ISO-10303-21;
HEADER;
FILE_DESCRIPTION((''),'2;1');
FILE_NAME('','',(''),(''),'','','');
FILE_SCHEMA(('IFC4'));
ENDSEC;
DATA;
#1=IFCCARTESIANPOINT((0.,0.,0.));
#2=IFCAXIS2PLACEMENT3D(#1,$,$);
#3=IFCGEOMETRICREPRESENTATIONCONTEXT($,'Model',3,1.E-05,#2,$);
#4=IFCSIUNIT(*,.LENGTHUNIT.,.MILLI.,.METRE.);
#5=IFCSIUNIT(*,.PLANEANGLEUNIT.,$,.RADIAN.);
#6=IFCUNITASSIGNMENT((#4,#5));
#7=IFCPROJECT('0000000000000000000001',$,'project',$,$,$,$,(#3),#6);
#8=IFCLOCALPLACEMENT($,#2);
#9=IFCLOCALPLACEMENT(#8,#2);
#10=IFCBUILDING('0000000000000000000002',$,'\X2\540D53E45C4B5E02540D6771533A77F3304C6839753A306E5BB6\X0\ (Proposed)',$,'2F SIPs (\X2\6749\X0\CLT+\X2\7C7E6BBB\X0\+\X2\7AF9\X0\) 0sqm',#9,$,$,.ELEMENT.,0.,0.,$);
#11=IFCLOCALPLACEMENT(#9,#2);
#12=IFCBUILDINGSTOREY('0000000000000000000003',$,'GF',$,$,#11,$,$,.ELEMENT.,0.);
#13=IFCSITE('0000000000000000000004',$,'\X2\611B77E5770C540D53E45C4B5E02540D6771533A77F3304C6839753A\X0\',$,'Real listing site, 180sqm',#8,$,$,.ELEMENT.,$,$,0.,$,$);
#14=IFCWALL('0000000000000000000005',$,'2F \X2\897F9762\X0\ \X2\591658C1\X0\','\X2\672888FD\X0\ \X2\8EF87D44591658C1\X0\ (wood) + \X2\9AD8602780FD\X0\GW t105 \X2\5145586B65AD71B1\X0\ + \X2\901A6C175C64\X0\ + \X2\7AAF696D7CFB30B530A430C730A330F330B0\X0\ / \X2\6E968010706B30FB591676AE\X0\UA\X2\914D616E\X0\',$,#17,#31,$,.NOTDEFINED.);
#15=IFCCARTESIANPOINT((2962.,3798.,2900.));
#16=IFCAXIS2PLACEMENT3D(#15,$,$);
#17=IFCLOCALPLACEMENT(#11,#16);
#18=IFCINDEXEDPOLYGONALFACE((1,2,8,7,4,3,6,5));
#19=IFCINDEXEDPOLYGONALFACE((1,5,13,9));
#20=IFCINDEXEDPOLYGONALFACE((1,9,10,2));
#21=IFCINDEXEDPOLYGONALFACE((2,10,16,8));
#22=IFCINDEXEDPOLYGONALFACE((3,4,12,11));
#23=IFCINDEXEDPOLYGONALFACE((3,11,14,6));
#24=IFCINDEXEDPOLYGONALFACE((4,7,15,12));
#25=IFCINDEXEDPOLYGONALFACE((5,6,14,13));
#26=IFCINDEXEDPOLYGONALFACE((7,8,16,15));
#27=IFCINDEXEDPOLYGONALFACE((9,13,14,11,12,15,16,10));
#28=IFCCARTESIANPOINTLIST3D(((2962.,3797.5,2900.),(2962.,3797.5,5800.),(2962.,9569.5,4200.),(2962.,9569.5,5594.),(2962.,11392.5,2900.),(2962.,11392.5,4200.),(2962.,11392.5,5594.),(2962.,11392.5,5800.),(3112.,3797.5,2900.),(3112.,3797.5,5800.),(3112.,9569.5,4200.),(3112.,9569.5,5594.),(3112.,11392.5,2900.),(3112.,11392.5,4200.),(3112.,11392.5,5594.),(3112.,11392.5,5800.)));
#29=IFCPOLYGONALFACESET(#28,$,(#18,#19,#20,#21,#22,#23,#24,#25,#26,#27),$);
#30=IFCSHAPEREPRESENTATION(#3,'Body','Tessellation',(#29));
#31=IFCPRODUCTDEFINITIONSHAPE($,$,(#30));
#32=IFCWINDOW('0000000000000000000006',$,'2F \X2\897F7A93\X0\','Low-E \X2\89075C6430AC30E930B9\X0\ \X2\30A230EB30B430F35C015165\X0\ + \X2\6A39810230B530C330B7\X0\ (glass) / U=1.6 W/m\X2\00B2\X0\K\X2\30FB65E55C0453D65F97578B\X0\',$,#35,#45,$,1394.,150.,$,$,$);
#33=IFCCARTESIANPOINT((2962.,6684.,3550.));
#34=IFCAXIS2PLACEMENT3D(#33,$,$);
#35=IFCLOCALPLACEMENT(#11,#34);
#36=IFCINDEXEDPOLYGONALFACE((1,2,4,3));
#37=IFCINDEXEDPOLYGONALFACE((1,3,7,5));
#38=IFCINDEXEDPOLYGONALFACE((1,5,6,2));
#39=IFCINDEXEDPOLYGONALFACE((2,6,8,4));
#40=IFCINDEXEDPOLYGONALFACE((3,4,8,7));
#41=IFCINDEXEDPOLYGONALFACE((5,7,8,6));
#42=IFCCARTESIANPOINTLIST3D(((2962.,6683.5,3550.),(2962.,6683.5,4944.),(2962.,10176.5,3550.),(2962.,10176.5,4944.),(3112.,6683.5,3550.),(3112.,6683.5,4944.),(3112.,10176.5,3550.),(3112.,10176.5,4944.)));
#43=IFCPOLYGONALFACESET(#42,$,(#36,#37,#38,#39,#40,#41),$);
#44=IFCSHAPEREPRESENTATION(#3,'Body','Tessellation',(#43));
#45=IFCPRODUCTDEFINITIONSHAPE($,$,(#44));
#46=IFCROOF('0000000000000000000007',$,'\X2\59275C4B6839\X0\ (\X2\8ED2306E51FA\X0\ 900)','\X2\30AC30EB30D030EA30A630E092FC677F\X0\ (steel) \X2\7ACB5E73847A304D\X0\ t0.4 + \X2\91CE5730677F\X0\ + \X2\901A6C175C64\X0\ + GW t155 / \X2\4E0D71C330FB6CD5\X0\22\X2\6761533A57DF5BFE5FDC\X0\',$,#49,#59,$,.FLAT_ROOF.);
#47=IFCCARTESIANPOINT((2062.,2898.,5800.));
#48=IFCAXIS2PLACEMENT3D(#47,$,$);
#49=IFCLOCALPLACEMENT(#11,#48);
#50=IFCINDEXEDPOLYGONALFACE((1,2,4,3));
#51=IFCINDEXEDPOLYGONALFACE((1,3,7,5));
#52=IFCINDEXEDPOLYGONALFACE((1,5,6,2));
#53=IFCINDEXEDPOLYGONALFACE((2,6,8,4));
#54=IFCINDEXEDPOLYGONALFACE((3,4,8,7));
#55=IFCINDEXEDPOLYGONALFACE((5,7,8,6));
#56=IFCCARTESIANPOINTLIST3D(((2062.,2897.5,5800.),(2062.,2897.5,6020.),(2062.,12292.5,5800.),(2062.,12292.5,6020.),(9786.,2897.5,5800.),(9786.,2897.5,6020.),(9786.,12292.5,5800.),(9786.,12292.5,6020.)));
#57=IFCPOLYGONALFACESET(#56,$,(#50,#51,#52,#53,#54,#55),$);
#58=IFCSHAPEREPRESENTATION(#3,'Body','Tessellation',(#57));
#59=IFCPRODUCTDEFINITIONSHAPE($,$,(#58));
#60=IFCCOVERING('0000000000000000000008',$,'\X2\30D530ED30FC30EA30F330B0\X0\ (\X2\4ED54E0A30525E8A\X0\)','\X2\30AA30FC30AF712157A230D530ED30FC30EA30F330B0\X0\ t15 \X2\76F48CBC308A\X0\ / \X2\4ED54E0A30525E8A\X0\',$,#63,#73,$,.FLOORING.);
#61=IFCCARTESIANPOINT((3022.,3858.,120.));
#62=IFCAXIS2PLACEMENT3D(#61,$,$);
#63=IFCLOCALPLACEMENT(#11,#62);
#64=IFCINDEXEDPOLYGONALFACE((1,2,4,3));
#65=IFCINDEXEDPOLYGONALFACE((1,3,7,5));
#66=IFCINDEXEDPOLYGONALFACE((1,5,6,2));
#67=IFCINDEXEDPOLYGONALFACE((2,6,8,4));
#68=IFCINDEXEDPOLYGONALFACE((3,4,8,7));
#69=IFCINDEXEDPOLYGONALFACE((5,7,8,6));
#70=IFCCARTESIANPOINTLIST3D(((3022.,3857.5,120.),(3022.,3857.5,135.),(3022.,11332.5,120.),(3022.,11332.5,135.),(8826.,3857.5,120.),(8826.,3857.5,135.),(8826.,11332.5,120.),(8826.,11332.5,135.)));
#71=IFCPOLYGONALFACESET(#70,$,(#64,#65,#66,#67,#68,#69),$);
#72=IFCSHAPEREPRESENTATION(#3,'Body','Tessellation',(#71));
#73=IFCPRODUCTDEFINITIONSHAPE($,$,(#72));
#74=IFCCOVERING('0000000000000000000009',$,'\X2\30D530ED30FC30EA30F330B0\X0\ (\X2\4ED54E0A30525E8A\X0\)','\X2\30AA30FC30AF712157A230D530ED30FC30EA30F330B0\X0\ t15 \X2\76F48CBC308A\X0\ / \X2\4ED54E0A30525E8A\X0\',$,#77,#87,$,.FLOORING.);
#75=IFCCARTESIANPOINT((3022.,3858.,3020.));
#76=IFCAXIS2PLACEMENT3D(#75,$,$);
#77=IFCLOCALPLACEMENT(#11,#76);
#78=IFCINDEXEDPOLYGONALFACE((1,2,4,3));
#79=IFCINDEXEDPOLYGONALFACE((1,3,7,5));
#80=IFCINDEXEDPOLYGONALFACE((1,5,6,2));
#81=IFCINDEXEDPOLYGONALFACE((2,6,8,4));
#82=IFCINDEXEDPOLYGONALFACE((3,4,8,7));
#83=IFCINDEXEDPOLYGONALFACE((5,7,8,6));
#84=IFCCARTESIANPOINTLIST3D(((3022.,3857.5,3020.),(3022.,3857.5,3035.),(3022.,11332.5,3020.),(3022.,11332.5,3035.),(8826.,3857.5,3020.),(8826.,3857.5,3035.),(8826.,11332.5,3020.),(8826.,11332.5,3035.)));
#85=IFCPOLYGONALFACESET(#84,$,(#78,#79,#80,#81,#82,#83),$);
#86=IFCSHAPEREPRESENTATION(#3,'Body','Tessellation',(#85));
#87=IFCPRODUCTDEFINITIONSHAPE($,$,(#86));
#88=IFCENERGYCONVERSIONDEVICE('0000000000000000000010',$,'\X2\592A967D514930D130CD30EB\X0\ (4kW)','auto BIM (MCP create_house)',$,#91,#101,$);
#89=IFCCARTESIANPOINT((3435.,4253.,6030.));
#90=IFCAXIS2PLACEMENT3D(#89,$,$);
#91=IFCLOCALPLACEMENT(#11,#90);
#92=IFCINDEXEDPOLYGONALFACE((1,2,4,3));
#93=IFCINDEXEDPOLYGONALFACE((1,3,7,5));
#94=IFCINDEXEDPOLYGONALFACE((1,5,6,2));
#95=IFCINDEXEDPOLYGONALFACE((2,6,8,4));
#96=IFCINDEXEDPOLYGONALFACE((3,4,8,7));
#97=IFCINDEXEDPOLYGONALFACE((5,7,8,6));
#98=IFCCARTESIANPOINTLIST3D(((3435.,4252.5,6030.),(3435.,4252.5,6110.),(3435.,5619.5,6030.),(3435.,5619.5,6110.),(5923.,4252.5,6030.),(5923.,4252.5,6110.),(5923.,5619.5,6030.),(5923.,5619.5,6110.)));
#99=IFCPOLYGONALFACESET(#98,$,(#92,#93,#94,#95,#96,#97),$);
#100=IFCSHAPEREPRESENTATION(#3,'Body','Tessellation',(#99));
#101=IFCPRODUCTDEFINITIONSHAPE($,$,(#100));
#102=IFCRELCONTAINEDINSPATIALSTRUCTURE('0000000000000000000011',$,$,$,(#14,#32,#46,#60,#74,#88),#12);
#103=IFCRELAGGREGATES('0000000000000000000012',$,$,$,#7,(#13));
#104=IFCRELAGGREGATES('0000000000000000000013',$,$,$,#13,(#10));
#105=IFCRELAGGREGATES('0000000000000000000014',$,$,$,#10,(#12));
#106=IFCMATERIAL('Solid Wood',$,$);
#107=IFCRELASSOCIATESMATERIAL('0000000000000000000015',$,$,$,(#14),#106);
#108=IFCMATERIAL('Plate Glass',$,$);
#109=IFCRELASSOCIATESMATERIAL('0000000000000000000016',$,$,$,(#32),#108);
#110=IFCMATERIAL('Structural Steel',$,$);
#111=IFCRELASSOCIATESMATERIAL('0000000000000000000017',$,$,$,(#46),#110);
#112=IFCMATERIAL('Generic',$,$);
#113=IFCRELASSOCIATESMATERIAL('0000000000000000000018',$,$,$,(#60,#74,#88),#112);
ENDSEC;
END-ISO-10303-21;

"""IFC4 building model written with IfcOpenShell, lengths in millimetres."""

from ifc_helpers import new_model, si_unit, frame, frame_2d, origin, place, context, project, spatial, rectangle, extrude, material, element, fill, save


model = new_model("IFC4")

# Units and contexts
model_context = context("Model", 3, precision=1e-05, world=origin())
ifc_project = project(units=[si_unit("LENGTHUNIT", "METRE", prefix="MILLI"), si_unit("PLANEANGLEUNIT", "RADIAN")], contexts=[model_context])

# Site, building, storey
site_placement = place(None, origin())
site = spatial("IfcSite", under=ifc_project, at=site_placement, Name="愛知県名古屋市名東区石が根町", ObjectType="Real listing site, 180sqm", CompositionType="ELEMENT", RefElevation=0.0)
building_placement = place(site_placement, origin())
building = spatial("IfcBuilding", under=site, at=building_placement, Name="名古屋市名東区石が根町の家 (Proposed)", ObjectType="2F SIPs (杉CLT+籾殻+竹) 0sqm", CompositionType="ELEMENT", ElevationOfRefHeight=0.0, ElevationOfTerrain=0.0)
storey_placement = place(building_placement, origin())
storey = spatial("IfcBuildingStorey", under=building, at=storey_placement, Name="GF", CompositionType="ELEMENT", Elevation=0.0)

# Shared definitions
ifc_material_1 = material(Name="Solid Wood")

# Shared definitions
ifc_material_2 = material(Name="Plate Glass")

# Wall, opening, window
wall_1_placement = place(storey_placement, frame((2962.0, 3798.0, 2900.0)))
wall_1 = element("IfcWall", 1, at=wall_1_placement, inside=storey, material=ifc_material_1, Name="2F 西面 外壁", Description="木製 軸組外壁 (wood) + 高性能GW t105 充填断熱 + 通気層 + 窯業系サイディング / 準耐火・外皮UA配慮", PredefinedType="NOTDEFINED", context=model_context, shape_type="SweptSolid", body=[
    extrude(rectangle(XDim=150.0, YDim=7595.0, at=frame_2d((75.0, 3797.0))), frame((2962.0, 3798.0, 2900.0)), (0.0, 0.0, 1.0), 2900.0),
])
opening_1_placement = place(storey_placement, frame((2962.0, 6684.0, 3550.0)))
opening_1 = element("IfcOpeningElement", 2, at=opening_1_placement, cuts=wall_1, PredefinedType="NOTDEFINED", context=model_context, shape_type="SweptSolid", body=[
    extrude(rectangle(XDim=150.0, YDim=3493.0, at=frame_2d((75.0, 1746.0))), frame((2962.0, 6684.0, 3550.0)), (0.0, 0.0, 1.0), 1394.0),
])
window_1_placement = place(storey_placement, frame((2962.0, 6684.0, 3550.0)))
window_1 = element("IfcWindow", 3, at=window_1_placement, inside=storey, material=ifc_material_2, Name="2F 西窓", Description="Low-E 複層ガラス アルゴン封入 + 樹脂サッシ (glass) / U=1.6 W/m²K・日射取得型", OverallHeight=1394.0, OverallWidth=150.0, context=model_context, shape_type="SweptSolid", body=[
    extrude(rectangle(XDim=150.0, YDim=3493.0, at=frame_2d((75.0, 1746.0))), frame((2962.0, 6684.0, 3550.0)), (0.0, 0.0, 1.0), 1394.0),
])
fill(opening_1, window_1)

# Roof
ifc_material_3 = material(Name="Structural Steel")
roof_placement = place(storey_placement, frame((2062.0, 2898.0, 5800.0)))
element("IfcRoof", 4, at=roof_placement, inside=storey, material=ifc_material_3, Name="大屋根 (軒の出 900)", Description="ガルバリウム鋼板 (steel) 立平葺き t0.4 + 野地板 + 通気層 + GW t155 / 不燃・法22条区域対応", PredefinedType="FLAT_ROOF", context=model_context, shape_type="SweptSolid", body=[
    extrude(rectangle(XDim=7724.0, YDim=9395.0, at=frame_2d((3862.0, 4697.0))), frame((2062.0, 2898.0, 5800.0)), (0.0, 0.0, 1.0), 220.0),
])

# Coverings
ifc_material_4 = material(Name="Generic")
covering_1_placement = place(storey_placement, frame((3022.0, 3858.0, 120.0)))
element("IfcCovering", 5, at=covering_1_placement, inside=storey, material=ifc_material_4, Name="フローリング (仕上げ床)", Description="オーク無垢フローリング t15 直貼り / 仕上げ床", PredefinedType="FLOORING", context=model_context, shape_type="SweptSolid", body=[
    extrude(rectangle(XDim=5804.0, YDim=7475.0, at=frame_2d((2902.0, 3737.0))), frame((3022.0, 3858.0, 120.0)), (0.0, 0.0, 1.0), 15.0),
])
covering_2_placement = place(storey_placement, frame((3022.0, 3858.0, 3020.0)))
element("IfcCovering", 6, at=covering_2_placement, inside=storey, material=ifc_material_4, Name="フローリング (仕上げ床)", Description="オーク無垢フローリング t15 直貼り / 仕上げ床", PredefinedType="FLOORING", context=model_context, shape_type="SweptSolid", body=[
    extrude(rectangle(XDim=5804.0, YDim=7475.0, at=frame_2d((2902.0, 3737.0))), frame((3022.0, 3858.0, 3020.0)), (0.0, 0.0, 1.0), 15.0),
])

# Energy conversion device
energy_conversion_device_placement = place(storey_placement, frame((3435.0, 4253.0, 6030.0)))
element("IfcEnergyConversionDevice", 7, at=energy_conversion_device_placement, inside=storey, material=ifc_material_4, Name="太陽光パネル (4kW)", Description="auto BIM (MCP create_house)", context=model_context, shape_type="SweptSolid", body=[
    extrude(rectangle(XDim=2488.0, YDim=1367.0, at=frame_2d((1244.0, 683.0))), frame((3435.0, 4253.0, 6030.0)), (0.0, 0.0, 1.0), 80.0),
])

save(model, "model.ifc")
